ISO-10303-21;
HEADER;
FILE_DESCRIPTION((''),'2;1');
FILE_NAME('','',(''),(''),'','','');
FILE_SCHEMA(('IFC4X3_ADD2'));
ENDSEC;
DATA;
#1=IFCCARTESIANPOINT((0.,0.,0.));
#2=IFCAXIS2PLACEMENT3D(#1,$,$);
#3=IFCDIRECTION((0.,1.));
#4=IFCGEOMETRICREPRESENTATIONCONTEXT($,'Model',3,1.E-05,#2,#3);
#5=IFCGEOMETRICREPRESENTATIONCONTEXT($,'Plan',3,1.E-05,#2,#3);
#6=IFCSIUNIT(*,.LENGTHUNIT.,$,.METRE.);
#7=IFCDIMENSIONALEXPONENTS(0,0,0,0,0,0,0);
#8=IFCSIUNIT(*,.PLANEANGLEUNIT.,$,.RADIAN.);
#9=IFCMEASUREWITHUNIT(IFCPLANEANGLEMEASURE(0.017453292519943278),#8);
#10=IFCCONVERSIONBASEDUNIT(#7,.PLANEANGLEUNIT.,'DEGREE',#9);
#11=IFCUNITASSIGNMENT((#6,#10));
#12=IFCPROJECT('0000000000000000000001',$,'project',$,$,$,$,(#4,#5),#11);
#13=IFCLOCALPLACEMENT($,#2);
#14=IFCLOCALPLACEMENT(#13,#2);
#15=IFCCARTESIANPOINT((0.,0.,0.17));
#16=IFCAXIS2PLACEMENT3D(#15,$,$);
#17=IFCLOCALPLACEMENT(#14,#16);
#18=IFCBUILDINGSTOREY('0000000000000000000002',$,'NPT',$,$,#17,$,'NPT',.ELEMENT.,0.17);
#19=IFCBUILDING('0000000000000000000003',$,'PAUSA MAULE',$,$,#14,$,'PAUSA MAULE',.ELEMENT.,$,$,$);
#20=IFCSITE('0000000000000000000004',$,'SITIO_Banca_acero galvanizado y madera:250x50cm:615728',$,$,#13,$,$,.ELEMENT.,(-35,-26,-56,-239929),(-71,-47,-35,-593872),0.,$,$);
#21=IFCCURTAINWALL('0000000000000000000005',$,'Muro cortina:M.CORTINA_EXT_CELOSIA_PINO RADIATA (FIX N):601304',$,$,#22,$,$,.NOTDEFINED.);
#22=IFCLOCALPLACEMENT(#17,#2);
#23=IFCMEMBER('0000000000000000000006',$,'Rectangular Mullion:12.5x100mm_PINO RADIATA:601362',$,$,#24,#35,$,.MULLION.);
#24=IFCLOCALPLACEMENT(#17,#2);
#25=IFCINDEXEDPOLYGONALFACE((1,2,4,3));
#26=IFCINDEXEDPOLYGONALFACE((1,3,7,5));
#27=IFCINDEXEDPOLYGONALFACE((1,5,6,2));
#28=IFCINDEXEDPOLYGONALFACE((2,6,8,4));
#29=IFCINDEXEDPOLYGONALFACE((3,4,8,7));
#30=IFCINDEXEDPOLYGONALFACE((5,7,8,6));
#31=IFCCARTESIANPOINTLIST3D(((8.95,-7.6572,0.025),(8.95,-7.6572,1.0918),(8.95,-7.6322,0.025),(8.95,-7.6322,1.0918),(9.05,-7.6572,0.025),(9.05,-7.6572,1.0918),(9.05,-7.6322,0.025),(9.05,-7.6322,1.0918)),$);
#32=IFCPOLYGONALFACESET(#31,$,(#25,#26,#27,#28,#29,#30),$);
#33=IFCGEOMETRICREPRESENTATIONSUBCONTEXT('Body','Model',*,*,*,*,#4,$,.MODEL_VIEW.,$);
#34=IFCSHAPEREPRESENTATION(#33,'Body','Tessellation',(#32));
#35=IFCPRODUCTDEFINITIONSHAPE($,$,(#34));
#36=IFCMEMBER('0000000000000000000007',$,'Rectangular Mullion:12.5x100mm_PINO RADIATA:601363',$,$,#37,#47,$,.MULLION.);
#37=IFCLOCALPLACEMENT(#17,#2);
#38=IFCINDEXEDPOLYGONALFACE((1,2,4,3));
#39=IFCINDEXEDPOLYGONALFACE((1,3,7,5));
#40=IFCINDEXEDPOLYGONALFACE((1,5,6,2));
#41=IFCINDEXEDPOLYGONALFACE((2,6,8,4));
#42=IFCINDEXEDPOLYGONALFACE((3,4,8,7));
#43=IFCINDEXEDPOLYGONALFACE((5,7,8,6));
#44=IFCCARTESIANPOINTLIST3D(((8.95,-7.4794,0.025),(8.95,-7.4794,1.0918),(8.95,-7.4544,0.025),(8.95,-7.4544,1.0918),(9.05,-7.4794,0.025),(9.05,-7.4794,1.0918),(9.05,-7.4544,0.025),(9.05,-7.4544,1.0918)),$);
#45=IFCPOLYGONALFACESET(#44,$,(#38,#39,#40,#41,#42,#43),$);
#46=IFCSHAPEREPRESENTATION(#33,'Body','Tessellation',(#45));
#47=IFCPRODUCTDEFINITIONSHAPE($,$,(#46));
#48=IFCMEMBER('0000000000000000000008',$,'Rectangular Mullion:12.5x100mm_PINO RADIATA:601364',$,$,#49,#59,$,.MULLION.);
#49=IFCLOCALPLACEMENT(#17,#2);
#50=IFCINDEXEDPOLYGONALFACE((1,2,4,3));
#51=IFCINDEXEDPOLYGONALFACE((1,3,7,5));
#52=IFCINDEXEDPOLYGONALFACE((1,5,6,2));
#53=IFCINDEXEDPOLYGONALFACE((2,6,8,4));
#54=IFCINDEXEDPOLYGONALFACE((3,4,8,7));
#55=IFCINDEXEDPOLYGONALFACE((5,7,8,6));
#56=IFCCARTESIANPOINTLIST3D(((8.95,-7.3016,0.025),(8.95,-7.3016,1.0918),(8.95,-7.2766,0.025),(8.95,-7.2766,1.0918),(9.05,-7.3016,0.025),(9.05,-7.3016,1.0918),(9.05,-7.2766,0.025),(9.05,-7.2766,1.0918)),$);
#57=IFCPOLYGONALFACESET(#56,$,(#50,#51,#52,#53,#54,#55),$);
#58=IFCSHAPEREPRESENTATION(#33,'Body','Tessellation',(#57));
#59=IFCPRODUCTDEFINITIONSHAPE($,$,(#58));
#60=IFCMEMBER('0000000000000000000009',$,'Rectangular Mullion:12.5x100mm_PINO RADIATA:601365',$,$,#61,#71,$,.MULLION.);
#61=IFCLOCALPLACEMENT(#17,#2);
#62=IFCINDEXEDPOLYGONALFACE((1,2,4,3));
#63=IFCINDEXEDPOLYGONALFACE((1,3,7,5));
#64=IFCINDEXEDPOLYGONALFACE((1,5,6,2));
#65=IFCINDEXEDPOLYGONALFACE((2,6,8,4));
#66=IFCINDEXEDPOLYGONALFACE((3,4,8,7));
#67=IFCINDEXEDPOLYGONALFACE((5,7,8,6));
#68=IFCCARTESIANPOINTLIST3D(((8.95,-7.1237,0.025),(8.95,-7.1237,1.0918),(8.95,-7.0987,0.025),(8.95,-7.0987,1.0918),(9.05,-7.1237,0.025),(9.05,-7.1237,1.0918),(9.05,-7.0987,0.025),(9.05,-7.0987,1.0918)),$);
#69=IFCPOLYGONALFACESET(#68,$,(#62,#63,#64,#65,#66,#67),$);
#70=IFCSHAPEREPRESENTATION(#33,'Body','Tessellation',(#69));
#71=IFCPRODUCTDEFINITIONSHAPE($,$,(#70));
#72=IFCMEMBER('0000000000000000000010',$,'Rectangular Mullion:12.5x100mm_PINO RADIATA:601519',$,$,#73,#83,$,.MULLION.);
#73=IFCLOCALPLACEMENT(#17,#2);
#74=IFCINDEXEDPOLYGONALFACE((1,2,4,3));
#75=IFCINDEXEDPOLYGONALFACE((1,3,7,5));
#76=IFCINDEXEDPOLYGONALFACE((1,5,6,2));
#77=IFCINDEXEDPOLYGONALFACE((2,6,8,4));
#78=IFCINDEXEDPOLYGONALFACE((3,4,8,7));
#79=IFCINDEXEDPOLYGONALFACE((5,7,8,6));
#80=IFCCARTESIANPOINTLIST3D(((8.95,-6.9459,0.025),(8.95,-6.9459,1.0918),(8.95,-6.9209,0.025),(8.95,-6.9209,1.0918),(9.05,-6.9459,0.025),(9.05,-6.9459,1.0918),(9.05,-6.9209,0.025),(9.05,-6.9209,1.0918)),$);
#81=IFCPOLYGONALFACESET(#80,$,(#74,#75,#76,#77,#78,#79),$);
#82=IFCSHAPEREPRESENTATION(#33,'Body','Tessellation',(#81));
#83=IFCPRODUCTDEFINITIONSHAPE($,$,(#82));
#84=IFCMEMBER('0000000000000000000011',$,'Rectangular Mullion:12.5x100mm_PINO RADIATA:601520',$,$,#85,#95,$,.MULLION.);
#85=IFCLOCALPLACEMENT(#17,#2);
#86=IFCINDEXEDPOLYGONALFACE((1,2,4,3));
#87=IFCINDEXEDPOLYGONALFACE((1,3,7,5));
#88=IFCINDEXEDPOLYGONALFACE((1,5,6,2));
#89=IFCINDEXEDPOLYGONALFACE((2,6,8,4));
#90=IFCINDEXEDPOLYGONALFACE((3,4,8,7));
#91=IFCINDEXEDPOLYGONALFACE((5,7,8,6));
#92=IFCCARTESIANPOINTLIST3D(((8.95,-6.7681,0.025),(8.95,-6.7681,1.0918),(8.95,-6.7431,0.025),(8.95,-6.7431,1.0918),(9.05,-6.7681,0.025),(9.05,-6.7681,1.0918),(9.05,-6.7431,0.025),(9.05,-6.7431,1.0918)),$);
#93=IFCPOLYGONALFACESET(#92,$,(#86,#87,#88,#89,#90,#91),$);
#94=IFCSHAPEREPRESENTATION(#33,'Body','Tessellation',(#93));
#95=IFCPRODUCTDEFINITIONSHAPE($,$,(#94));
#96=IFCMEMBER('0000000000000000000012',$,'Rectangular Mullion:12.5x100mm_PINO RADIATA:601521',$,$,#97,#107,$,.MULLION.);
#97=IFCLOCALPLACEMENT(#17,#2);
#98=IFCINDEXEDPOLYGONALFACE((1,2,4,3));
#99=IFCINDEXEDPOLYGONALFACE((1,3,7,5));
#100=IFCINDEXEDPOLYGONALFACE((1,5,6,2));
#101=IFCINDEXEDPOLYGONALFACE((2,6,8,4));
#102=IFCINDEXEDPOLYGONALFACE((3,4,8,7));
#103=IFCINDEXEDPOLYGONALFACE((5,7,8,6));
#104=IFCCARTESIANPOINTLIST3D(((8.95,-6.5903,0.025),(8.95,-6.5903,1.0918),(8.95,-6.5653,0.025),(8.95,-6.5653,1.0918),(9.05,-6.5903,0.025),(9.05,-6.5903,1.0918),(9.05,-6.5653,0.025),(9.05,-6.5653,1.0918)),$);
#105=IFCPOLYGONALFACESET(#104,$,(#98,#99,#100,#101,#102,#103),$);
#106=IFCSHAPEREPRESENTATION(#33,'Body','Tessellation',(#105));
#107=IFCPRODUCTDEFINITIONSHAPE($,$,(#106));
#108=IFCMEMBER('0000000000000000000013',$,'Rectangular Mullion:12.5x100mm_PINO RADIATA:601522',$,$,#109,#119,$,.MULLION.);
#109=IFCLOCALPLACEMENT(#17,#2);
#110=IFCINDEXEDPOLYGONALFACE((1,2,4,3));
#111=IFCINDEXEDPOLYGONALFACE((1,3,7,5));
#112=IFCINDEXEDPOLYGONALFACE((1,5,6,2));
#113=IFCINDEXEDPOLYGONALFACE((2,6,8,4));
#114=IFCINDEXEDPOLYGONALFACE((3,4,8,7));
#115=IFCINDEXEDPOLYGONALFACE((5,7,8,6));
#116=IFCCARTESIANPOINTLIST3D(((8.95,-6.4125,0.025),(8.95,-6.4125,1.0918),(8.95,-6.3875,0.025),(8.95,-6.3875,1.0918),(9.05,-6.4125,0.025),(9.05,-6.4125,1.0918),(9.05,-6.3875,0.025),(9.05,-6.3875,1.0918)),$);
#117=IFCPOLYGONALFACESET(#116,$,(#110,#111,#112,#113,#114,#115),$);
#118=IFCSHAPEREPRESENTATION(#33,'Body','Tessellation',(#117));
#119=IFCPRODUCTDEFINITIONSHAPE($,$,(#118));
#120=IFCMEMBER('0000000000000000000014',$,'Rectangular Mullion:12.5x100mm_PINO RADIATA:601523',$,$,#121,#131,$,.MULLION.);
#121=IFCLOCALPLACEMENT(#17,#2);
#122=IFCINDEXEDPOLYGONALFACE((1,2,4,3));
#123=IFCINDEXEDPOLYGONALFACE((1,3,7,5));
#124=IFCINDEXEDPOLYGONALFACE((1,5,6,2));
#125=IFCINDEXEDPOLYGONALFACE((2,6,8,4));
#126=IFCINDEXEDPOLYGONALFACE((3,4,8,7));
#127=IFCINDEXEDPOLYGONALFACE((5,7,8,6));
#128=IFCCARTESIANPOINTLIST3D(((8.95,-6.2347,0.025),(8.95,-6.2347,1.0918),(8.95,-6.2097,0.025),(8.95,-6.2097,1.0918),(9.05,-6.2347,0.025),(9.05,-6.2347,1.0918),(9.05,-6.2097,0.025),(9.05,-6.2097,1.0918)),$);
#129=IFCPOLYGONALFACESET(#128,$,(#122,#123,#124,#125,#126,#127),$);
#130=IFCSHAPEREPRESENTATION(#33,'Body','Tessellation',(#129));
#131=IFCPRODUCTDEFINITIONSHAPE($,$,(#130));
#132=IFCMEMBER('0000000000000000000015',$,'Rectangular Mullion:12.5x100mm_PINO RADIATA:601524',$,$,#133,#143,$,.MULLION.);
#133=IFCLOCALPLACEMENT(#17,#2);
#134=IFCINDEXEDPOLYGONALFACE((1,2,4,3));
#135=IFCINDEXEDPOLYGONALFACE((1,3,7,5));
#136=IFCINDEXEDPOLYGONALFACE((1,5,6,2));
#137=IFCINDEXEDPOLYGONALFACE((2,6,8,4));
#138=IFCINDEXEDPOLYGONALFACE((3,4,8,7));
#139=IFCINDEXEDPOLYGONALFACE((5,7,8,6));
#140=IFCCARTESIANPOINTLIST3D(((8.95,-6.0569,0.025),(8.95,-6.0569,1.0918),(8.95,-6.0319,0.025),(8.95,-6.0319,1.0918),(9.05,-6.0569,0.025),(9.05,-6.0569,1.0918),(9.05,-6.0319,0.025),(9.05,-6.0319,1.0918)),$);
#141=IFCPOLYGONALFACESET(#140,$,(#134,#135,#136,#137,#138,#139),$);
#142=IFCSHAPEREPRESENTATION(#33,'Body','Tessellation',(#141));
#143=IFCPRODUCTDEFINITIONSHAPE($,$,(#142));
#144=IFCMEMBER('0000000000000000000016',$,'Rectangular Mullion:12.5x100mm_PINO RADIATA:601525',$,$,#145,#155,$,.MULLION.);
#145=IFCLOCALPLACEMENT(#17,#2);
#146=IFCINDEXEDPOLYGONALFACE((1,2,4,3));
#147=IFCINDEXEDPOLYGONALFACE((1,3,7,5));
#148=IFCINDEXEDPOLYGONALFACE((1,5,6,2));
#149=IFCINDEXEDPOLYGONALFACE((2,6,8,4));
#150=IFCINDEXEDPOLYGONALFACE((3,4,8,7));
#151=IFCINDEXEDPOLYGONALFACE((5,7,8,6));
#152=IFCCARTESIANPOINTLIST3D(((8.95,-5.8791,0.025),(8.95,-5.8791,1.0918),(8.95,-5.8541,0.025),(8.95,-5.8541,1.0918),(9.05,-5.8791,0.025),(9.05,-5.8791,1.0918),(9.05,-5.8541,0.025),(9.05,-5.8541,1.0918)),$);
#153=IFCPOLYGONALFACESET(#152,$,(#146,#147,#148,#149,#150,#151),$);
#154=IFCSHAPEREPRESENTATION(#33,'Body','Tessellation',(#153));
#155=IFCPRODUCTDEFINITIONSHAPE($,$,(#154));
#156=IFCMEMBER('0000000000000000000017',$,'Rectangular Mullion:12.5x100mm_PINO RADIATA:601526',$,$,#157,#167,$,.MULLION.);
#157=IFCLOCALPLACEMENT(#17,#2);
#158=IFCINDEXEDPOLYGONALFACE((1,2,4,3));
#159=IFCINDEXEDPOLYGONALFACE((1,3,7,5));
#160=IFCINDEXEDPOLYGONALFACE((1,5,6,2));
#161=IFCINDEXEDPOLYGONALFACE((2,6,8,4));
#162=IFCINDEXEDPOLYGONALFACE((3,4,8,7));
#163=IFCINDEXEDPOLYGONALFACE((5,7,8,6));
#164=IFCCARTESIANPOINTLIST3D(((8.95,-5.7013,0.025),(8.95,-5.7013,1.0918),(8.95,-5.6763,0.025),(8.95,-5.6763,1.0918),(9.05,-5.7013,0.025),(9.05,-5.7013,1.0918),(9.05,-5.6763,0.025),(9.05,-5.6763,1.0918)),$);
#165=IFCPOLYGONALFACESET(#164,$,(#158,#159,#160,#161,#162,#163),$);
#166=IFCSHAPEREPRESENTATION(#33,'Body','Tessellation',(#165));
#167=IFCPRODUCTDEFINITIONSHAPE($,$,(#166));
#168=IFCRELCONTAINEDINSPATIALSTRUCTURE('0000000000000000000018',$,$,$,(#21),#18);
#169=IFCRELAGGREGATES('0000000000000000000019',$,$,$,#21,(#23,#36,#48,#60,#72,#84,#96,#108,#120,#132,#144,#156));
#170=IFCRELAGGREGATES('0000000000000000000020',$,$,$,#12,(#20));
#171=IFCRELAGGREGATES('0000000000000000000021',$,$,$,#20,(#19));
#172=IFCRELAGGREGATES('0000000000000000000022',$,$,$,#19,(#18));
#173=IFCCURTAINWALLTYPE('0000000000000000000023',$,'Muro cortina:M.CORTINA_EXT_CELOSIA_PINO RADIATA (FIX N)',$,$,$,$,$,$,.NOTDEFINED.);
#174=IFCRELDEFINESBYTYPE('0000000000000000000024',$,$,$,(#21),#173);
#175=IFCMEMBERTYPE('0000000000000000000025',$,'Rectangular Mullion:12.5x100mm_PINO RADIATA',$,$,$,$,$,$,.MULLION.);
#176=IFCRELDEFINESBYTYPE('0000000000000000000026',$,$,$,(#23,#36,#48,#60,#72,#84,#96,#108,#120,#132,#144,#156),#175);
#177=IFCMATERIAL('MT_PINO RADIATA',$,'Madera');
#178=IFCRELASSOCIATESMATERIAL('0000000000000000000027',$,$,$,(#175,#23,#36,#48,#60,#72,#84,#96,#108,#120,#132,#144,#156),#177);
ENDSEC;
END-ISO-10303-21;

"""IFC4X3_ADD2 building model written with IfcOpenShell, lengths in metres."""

from ifc_helpers import new_model, entity, si_unit, converted_unit, direction, frame, frame_2d, origin, origin_2d_with_axis, place, context, subcontext, project, spatial, rectangle, extrude, source, transform, mapped, material, material_profile, profile_set, profile_usage, type_object, type_shapes, element, aggregate, save


model = new_model("IFC4X3_ADD2")

# Units and contexts
model_context = context("Model", 3, precision=1e-05, world=origin(), true_north=direction((0.0, 1.0)))
plan_context = context("Plan", 3, precision=1e-05, world=origin(), true_north=direction((0.0, 1.0)))
body_context = subcontext(model_context, "Body", "Model", "MODEL_VIEW")
ifc_project = project(units=[si_unit("LENGTHUNIT", "METRE"), converted_unit("PLANEANGLEUNIT", "DEGREE", entity("IfcPlaneAngleMeasure", 0.017453292519943278), si_unit("PLANEANGLEUNIT", "RADIAN"), dimensions=[0, 0, 0, 0, 0, 0, 0])], contexts=[model_context, plan_context])

# Site, building, storey
site_placement = place(None, origin())
site = spatial("IfcSite", under=ifc_project, at=site_placement, Name="SITIO_Banca_acero galvanizado y madera:250x50cm:615728", CompositionType="ELEMENT", RefLatitude=(-35, -26, -56, -239929), RefLongitude=(-71, -47, -35, -593872), RefElevation=0.0)
building_placement = place(site_placement, origin())
building = spatial("IfcBuilding", under=site, at=building_placement, Name="PAUSA MAULE", LongName="PAUSA MAULE", CompositionType="ELEMENT")
storey_placement = place(building_placement, frame((0.0, 0.0, 0.17)))
storey = spatial("IfcBuildingStorey", under=building, at=storey_placement, Name="NPT", LongName="NPT", CompositionType="ELEMENT", Elevation=0.17)

# Curtain wall, members
curtain_wall_type = type_object("IfcCurtainWallType", Name="Muro cortina:M.CORTINA_EXT_CELOSIA_PINO RADIATA (FIX N)", PredefinedType="NOTDEFINED")
curtain_wall_placement = place(storey_placement, frame((0.0, 0.0, -0.17)))
curtain_wall = element("IfcCurtainWall", 1, at=curtain_wall_placement, inside=storey, type_object=curtain_wall_type, Name="Muro cortina:M.CORTINA_EXT_CELOSIA_PINO RADIATA (FIX N):601304", PredefinedType="NOTDEFINED")
ifc_material = material(Name="MT_PINO RADIATA", Category="Madera")
ifc_material_profile = material_profile(ifc_material, rectangle(XDim=0.025, YDim=0.1, at=frame_2d((0.0, 0.0), x_axis=(1.0, 0.0))), Name="12.5x100mm_PINO RADIATA")
ifc_profile_set = profile_set([ifc_material_profile], Name="12.5x100mm_PINO RADIATA")
ifc_profile_usage = profile_usage(ifc_profile_set)
member_type_1 = type_object("IfcMemberType", Name="Rectangular Mullion:12.5x100mm_PINO RADIATA", PredefinedType="MULLION", material=ifc_profile_set)
shared_shape_1 = source(origin(), body_context, "Body", "SweptSolid", [
    extrude(rectangle(XDim=0.025, YDim=0.1, at=origin_2d_with_axis()), frame((0.0, 0.0, -1.0668), z_axis=(0.0, 0.0, 1.0), x_axis=(-1.0, 0.0, 0.0)), (0.0, 0.0, 1.0), 1.0668),
])
type_shapes(member_type_1, [shared_shape_1])
member_1_placement = place(curtain_wall_placement, frame((9.0, -7.6447, 0.195), z_axis=(0.0, 0.0, -1.0), x_axis=(0.0, 1.0, 0.0)))
member_1 = element("IfcMember", 2, at=member_1_placement, type_object=member_type_1, material=ifc_profile_usage, Name="Rectangular Mullion:12.5x100mm_PINO RADIATA:601362", PredefinedType="MULLION", context=body_context, shape_type="MappedRepresentation", body=[
    mapped(shared_shape_1, transform((0.0, 0.0, 0.0), scale=1.0)),
])
member_2_placement = place(curtain_wall_placement, frame((9.0, -7.4669, 0.195), z_axis=(0.0, 0.0, -1.0), x_axis=(0.0, 1.0, 0.0)))
member_2 = element("IfcMember", 3, at=member_2_placement, type_object=member_type_1, material=ifc_profile_usage, Name="Rectangular Mullion:12.5x100mm_PINO RADIATA:601363", PredefinedType="MULLION", context=body_context, shape_type="MappedRepresentation", body=[
    mapped(shared_shape_1, transform((0.0, 0.0, 0.0), scale=1.0)),
])
member_3_placement = place(curtain_wall_placement, frame((9.0, -7.2891, 0.195), z_axis=(0.0, 0.0, -1.0), x_axis=(0.0, 1.0, 0.0)))
member_3 = element("IfcMember", 4, at=member_3_placement, type_object=member_type_1, material=ifc_profile_usage, Name="Rectangular Mullion:12.5x100mm_PINO RADIATA:601364", PredefinedType="MULLION", context=body_context, shape_type="MappedRepresentation", body=[
    mapped(shared_shape_1, transform((0.0, 0.0, 0.0), scale=1.0)),
])
member_4_placement = place(curtain_wall_placement, frame((9.0, -7.1112, 0.195), z_axis=(0.0, 0.0, -1.0), x_axis=(0.0, 1.0, 0.0)))
member_4 = element("IfcMember", 5, at=member_4_placement, type_object=member_type_1, material=ifc_profile_usage, Name="Rectangular Mullion:12.5x100mm_PINO RADIATA:601365", PredefinedType="MULLION", context=body_context, shape_type="MappedRepresentation", body=[
    mapped(shared_shape_1, transform((0.0, 0.0, 0.0), scale=1.0)),
])
member_5_placement = place(curtain_wall_placement, frame((9.0, -6.9334, 0.195), z_axis=(0.0, 0.0, -1.0), x_axis=(0.0, 1.0, 0.0)))
member_5 = element("IfcMember", 6, at=member_5_placement, type_object=member_type_1, material=ifc_profile_usage, Name="Rectangular Mullion:12.5x100mm_PINO RADIATA:601519", PredefinedType="MULLION", context=body_context, shape_type="MappedRepresentation", body=[
    mapped(shared_shape_1, transform((0.0, 0.0, 0.0), scale=1.0)),
])
member_6_placement = place(curtain_wall_placement, frame((9.0, -6.7556, 0.195), z_axis=(0.0, 0.0, -1.0), x_axis=(0.0, 1.0, 0.0)))
member_6 = element("IfcMember", 7, at=member_6_placement, type_object=member_type_1, material=ifc_profile_usage, Name="Rectangular Mullion:12.5x100mm_PINO RADIATA:601520", PredefinedType="MULLION", context=body_context, shape_type="MappedRepresentation", body=[
    mapped(shared_shape_1, transform((0.0, 0.0, 0.0), scale=1.0)),
])
member_7_placement = place(curtain_wall_placement, frame((9.0, -6.5778, 0.195), z_axis=(0.0, 0.0, -1.0), x_axis=(0.0, 1.0, 0.0)))
member_7 = element("IfcMember", 8, at=member_7_placement, type_object=member_type_1, material=ifc_profile_usage, Name="Rectangular Mullion:12.5x100mm_PINO RADIATA:601521", PredefinedType="MULLION", context=body_context, shape_type="MappedRepresentation", body=[
    mapped(shared_shape_1, transform((0.0, 0.0, 0.0), scale=1.0)),
])
member_8_placement = place(curtain_wall_placement, frame((9.0, -6.4, 0.195), z_axis=(0.0, 0.0, -1.0), x_axis=(0.0, 1.0, 0.0)))
member_8 = element("IfcMember", 9, at=member_8_placement, type_object=member_type_1, material=ifc_profile_usage, Name="Rectangular Mullion:12.5x100mm_PINO RADIATA:601522", PredefinedType="MULLION", context=body_context, shape_type="MappedRepresentation", body=[
    mapped(shared_shape_1, transform((0.0, 0.0, 0.0), scale=1.0)),
])
member_9_placement = place(curtain_wall_placement, frame((9.0, -6.2222, 0.195), z_axis=(0.0, 0.0, -1.0), x_axis=(0.0, 1.0, 0.0)))
member_9 = element("IfcMember", 10, at=member_9_placement, type_object=member_type_1, material=ifc_profile_usage, Name="Rectangular Mullion:12.5x100mm_PINO RADIATA:601523", PredefinedType="MULLION", context=body_context, shape_type="MappedRepresentation", body=[
    mapped(shared_shape_1, transform((0.0, 0.0, 0.0), scale=1.0)),
])
member_10_placement = place(curtain_wall_placement, frame((9.0, -6.0444, 0.195), z_axis=(0.0, 0.0, -1.0), x_axis=(0.0, 1.0, 0.0)))
member_10 = element("IfcMember", 11, at=member_10_placement, type_object=member_type_1, material=ifc_profile_usage, Name="Rectangular Mullion:12.5x100mm_PINO RADIATA:601524", PredefinedType="MULLION", context=body_context, shape_type="MappedRepresentation", body=[
    mapped(shared_shape_1, transform((0.0, 0.0, 0.0), scale=1.0)),
])
member_11_placement = place(curtain_wall_placement, frame((9.0, -5.8666, 0.195), z_axis=(0.0, 0.0, -1.0), x_axis=(0.0, 1.0, 0.0)))
member_11 = element("IfcMember", 12, at=member_11_placement, type_object=member_type_1, material=ifc_profile_usage, Name="Rectangular Mullion:12.5x100mm_PINO RADIATA:601525", PredefinedType="MULLION", context=body_context, shape_type="MappedRepresentation", body=[
    mapped(shared_shape_1, transform((0.0, 0.0, 0.0), scale=1.0)),
])
member_12_placement = place(curtain_wall_placement, frame((9.0, -5.6888, 0.195), z_axis=(0.0, 0.0, -1.0), x_axis=(0.0, 1.0, 0.0)))
member_12 = element("IfcMember", 13, at=member_12_placement, type_object=member_type_1, material=ifc_profile_usage, Name="Rectangular Mullion:12.5x100mm_PINO RADIATA:601526", PredefinedType="MULLION", context=body_context, shape_type="MappedRepresentation", body=[
    mapped(shared_shape_1, transform((0.0, 0.0, 0.0), scale=1.0)),
])
aggregate(curtain_wall, [member_1, member_2, member_3, member_4, member_5, member_6, member_7, member_8, member_9, member_10, member_11, member_12])

save(model, "model.ifc")
